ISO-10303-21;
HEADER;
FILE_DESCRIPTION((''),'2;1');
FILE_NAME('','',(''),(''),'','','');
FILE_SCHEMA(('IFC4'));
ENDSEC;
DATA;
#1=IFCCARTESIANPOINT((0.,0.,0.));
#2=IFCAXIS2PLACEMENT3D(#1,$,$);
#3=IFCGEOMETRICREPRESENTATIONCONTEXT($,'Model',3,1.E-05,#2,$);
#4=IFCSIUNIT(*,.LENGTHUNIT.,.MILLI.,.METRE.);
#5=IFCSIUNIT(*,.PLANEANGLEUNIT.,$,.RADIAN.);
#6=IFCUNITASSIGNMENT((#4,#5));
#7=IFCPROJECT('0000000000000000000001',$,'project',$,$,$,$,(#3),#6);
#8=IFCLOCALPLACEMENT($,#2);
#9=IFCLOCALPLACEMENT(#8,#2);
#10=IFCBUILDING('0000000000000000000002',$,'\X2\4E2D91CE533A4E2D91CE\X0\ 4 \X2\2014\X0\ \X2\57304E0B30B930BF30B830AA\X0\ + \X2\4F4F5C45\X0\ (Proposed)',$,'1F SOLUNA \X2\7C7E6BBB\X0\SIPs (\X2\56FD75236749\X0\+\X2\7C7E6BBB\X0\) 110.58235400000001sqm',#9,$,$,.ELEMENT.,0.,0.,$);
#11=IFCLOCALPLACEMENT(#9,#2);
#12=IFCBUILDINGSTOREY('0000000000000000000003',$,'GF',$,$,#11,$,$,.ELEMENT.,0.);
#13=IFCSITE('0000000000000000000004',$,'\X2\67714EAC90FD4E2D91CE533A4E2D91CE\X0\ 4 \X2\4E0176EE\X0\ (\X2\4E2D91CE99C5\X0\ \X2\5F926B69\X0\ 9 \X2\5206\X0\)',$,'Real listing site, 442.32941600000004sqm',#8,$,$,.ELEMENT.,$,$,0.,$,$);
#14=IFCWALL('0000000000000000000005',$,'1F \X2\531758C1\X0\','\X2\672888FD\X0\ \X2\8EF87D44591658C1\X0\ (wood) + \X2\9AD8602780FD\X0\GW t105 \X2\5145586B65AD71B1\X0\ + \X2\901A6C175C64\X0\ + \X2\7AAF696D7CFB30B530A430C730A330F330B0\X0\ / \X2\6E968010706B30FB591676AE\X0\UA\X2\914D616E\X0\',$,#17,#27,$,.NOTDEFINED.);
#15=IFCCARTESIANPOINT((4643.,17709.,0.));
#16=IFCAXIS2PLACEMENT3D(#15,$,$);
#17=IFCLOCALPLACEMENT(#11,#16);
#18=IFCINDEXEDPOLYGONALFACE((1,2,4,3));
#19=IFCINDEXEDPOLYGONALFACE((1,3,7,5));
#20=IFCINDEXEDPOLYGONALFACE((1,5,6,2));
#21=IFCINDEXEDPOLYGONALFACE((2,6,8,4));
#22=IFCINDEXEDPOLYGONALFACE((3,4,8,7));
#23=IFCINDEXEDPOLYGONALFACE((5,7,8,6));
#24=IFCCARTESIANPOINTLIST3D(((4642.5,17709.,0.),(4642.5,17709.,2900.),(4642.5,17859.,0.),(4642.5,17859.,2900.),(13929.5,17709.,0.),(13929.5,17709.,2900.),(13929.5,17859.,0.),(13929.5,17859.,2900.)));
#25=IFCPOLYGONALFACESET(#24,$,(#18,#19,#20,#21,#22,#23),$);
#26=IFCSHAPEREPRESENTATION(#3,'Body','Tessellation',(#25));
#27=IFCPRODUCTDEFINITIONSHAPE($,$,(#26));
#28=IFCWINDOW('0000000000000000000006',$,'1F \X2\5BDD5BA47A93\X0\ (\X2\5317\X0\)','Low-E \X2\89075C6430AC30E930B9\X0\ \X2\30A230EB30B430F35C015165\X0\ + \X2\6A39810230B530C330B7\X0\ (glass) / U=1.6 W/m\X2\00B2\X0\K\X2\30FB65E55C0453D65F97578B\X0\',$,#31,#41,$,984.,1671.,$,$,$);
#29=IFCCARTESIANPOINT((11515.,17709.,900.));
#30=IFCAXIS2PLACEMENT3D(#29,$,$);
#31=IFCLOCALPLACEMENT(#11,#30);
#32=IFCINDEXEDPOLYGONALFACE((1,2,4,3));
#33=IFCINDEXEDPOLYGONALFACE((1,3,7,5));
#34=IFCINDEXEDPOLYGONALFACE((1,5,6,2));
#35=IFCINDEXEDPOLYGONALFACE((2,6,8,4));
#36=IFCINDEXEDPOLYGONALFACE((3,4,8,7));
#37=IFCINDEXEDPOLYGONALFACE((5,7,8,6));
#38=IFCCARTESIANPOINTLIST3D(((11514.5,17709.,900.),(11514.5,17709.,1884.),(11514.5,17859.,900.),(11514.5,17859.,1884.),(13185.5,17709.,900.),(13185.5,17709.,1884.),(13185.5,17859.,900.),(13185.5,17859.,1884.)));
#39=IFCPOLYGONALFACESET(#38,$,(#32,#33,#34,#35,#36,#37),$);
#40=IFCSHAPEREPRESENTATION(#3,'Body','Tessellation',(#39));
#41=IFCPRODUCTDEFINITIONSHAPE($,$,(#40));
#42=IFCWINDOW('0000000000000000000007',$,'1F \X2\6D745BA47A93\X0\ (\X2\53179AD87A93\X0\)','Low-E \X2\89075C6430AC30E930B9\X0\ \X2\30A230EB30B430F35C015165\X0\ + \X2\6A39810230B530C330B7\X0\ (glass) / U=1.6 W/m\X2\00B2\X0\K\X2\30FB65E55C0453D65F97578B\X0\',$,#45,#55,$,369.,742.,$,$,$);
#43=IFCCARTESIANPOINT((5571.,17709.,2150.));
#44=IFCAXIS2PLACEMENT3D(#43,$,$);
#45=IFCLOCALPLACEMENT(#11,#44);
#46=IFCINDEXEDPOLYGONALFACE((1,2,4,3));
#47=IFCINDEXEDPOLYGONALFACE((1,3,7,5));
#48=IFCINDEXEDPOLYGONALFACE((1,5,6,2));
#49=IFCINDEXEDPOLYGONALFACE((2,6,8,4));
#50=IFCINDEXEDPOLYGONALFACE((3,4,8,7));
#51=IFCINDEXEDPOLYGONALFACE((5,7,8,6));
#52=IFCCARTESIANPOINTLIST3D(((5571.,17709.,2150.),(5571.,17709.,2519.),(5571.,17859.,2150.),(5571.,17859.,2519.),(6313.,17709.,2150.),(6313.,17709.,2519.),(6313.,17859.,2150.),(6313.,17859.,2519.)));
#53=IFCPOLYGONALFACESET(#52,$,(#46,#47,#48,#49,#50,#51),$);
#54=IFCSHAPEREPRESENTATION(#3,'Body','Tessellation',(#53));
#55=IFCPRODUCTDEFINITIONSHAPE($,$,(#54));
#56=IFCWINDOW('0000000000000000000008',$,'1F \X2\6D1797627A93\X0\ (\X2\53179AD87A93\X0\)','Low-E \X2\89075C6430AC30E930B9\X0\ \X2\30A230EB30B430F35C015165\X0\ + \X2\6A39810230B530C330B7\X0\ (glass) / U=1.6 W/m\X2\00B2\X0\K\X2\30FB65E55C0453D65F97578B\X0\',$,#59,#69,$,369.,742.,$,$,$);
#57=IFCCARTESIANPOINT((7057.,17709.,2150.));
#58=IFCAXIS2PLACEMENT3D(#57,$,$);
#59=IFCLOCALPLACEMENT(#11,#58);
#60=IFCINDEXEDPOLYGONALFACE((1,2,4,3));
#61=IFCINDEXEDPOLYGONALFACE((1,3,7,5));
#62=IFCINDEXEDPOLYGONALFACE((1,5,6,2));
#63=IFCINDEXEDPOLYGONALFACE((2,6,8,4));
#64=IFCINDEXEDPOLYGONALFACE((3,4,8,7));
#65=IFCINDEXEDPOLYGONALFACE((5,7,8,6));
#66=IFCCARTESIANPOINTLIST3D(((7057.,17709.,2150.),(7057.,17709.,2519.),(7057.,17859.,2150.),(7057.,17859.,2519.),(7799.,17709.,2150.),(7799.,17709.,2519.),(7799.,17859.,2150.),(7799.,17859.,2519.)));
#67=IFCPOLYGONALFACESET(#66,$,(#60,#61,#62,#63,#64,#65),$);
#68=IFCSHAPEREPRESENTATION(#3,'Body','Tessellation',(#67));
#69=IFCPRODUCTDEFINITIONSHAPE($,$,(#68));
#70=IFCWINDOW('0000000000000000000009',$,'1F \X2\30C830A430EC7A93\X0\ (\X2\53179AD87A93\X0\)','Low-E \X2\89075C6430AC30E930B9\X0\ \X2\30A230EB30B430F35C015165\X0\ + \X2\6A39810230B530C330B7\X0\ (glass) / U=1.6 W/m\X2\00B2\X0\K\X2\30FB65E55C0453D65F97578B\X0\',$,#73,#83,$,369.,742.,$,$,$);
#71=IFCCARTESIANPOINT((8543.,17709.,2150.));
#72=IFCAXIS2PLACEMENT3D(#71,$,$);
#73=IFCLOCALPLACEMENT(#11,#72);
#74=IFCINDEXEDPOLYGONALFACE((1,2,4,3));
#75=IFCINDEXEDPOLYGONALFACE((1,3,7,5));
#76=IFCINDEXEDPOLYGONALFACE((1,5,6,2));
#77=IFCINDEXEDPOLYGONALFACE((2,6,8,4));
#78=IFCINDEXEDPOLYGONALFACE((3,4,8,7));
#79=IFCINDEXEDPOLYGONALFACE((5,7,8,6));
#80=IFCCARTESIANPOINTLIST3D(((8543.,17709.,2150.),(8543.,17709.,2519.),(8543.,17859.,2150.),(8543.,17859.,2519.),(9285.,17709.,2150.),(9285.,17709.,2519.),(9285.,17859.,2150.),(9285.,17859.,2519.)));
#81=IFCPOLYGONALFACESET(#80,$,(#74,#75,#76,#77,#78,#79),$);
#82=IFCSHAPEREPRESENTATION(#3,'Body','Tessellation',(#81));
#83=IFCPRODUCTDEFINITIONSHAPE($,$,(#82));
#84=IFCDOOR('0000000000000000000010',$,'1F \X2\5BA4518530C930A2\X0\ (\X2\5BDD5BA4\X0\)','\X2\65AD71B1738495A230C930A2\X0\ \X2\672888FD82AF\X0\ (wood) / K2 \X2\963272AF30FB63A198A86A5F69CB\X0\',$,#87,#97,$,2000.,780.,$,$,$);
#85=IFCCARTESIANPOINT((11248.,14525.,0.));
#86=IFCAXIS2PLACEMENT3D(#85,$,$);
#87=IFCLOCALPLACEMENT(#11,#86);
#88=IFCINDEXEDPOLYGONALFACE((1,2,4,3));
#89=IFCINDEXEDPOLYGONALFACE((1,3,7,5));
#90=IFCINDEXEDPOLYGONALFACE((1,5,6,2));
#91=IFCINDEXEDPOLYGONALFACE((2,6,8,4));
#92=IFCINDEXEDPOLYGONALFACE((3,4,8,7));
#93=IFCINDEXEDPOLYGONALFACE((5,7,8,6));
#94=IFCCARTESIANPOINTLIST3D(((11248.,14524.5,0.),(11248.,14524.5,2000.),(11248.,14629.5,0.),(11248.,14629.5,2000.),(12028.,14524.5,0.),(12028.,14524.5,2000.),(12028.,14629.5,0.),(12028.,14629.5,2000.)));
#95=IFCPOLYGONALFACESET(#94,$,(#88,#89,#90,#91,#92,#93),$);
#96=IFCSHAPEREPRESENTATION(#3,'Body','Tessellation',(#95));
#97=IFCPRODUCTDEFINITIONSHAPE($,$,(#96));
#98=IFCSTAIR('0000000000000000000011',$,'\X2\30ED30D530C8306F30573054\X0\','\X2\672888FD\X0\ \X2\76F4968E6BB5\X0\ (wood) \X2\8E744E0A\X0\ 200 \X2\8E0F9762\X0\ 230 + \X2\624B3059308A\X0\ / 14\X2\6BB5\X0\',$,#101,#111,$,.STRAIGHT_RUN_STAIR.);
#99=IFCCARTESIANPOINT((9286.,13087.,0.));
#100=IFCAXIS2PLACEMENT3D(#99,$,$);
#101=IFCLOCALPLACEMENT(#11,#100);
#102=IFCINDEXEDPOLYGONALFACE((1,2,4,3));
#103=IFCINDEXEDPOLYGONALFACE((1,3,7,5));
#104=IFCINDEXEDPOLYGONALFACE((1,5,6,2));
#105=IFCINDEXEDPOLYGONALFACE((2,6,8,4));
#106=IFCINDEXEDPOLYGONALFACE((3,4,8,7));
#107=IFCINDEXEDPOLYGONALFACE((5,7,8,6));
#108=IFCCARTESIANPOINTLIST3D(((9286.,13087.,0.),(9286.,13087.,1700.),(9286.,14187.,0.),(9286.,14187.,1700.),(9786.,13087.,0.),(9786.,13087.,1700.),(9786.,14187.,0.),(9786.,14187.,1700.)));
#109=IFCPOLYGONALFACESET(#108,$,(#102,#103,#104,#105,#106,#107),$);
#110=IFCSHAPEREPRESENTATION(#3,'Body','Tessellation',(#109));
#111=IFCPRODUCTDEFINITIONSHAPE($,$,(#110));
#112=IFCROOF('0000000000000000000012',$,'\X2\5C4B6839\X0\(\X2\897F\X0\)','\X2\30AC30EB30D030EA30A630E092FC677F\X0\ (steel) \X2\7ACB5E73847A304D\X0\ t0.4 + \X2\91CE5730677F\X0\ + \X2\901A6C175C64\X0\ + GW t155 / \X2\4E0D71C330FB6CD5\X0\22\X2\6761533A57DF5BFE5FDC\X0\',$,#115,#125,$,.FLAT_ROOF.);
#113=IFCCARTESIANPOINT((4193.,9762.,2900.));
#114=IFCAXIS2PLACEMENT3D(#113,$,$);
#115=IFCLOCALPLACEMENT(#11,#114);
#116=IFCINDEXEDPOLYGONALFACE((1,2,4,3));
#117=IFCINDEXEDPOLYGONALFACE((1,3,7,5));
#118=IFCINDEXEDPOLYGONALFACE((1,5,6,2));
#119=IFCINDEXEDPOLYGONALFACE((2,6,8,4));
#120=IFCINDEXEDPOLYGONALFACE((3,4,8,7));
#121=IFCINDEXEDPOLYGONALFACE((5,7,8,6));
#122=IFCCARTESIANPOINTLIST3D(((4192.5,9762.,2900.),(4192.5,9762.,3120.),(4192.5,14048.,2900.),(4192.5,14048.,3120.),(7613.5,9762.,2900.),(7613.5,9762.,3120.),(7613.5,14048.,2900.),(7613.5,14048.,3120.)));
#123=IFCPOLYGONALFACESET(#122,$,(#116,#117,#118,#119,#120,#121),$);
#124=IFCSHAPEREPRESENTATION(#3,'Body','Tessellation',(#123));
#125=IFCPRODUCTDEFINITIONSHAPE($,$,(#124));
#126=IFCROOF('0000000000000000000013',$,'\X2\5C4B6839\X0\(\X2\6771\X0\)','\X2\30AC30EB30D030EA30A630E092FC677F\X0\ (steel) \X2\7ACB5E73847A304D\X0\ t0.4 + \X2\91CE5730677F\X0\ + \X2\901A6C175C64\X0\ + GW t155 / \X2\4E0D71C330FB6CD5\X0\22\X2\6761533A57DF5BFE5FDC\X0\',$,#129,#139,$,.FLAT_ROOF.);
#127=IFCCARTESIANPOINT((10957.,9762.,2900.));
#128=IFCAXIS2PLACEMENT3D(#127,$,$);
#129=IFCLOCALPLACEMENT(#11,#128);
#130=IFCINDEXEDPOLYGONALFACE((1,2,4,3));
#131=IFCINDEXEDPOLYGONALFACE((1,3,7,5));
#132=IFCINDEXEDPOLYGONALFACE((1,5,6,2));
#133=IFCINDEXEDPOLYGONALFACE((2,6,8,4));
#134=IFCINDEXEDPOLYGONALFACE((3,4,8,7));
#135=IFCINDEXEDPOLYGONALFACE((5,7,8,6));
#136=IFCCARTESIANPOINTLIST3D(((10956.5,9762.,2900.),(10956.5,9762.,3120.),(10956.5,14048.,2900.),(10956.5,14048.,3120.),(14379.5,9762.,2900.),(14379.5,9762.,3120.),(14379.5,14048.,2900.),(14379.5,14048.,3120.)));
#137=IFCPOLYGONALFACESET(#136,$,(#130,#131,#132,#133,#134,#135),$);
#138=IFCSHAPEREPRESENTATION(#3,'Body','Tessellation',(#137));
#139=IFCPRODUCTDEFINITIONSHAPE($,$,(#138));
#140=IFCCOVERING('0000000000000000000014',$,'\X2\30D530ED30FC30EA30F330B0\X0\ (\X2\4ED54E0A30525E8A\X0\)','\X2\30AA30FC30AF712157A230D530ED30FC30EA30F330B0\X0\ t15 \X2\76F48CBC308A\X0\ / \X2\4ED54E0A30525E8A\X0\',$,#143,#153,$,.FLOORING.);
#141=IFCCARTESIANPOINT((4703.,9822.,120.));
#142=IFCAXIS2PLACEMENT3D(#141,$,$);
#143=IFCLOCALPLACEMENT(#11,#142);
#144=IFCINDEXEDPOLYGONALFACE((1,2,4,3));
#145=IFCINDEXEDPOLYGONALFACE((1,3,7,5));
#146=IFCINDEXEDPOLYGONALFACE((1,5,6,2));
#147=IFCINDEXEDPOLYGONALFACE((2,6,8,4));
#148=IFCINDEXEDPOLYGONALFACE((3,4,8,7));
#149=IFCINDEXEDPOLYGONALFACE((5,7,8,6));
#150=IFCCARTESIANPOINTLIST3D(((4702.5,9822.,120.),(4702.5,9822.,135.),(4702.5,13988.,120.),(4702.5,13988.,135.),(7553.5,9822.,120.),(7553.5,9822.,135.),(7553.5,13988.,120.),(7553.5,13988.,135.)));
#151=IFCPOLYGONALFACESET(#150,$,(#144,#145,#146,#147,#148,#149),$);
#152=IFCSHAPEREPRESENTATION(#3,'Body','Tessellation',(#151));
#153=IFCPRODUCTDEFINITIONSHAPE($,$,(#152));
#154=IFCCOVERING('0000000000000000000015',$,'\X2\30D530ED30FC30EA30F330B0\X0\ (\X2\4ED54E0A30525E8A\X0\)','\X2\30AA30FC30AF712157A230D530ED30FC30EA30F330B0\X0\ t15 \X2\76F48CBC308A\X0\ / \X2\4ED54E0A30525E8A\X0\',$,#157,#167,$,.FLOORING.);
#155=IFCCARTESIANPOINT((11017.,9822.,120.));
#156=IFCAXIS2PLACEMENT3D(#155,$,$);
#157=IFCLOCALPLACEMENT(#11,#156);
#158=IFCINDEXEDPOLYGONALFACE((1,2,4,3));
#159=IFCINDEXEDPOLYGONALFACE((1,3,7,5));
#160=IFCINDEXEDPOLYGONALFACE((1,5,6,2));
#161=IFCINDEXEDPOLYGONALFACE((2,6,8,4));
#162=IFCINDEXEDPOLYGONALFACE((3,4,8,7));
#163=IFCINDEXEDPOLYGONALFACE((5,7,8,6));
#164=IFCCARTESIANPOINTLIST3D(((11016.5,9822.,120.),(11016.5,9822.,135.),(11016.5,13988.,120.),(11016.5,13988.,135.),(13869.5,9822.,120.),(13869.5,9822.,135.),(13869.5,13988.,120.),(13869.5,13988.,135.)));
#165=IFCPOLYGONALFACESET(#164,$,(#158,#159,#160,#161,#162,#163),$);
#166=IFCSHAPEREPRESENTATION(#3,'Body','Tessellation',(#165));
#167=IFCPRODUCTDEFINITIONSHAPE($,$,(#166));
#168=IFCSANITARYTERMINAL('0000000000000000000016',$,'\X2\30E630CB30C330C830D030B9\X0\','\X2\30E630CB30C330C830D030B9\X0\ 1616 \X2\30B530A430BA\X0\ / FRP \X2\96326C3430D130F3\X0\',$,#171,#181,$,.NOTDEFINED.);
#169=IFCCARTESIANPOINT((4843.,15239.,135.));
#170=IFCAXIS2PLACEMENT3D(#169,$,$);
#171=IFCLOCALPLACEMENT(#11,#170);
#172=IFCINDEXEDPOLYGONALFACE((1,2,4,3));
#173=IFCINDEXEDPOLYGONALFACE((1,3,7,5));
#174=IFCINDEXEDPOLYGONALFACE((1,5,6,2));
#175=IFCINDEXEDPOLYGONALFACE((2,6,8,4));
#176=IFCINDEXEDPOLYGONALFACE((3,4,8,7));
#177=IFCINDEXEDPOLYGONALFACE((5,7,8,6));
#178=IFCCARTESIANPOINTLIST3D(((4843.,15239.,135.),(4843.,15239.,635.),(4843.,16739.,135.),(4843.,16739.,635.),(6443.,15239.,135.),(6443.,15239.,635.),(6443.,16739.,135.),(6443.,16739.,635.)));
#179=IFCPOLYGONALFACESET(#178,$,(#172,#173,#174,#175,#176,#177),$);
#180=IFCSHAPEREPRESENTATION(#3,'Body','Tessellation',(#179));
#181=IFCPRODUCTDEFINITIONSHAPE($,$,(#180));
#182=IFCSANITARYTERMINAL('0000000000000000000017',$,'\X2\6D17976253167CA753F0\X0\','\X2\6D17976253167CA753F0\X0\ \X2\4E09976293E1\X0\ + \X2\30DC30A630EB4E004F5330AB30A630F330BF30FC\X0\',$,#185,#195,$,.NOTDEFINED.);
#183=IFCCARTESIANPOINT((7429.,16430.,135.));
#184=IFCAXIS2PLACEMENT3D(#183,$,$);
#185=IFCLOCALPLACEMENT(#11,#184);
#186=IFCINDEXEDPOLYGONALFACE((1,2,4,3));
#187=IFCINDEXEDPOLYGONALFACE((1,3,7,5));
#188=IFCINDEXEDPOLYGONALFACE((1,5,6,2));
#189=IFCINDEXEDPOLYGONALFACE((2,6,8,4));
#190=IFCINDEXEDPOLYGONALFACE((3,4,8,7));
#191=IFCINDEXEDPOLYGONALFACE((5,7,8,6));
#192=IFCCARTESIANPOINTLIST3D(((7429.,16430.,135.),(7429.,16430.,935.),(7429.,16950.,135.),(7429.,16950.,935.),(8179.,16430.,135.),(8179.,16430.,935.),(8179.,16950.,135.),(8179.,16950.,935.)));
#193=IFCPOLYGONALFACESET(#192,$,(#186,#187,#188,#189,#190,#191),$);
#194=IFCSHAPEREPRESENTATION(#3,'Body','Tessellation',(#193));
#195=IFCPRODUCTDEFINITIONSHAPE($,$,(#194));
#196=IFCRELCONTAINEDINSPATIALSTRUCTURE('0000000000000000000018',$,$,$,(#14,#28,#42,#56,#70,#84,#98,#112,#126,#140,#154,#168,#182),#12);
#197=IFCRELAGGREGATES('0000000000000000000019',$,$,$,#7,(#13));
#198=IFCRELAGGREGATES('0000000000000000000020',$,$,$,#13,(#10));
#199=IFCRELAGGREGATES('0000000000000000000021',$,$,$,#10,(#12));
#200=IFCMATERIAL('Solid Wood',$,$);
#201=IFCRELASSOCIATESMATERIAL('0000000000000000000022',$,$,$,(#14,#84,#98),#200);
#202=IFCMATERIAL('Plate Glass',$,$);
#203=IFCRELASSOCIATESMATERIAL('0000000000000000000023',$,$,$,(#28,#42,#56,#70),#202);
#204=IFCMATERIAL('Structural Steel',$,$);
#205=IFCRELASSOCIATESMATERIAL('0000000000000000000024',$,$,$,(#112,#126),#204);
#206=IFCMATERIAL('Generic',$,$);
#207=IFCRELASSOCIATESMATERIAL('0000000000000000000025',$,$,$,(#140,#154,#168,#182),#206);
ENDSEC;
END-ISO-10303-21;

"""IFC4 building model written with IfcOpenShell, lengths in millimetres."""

from ifc_helpers import new_model, si_unit, frame, frame_2d, origin, place, context, project, spatial, rectangle, extrude, material, element, fill, save


model = new_model("IFC4")

# Units and contexts
model_context = context("Model", 3, precision=1e-05, world=origin())
ifc_project = project(units=[si_unit("LENGTHUNIT", "METRE", prefix="MILLI"), si_unit("PLANEANGLEUNIT", "RADIAN")], contexts=[model_context])

# Site, building, storey
site_placement = place(None, origin())
site = spatial("IfcSite", under=ifc_project, at=site_placement, Name="東京都中野区中野 4 丁目 (中野駅 徒歩 9 分)", ObjectType="Real listing site, 442.32941600000004sqm", CompositionType="ELEMENT", RefElevation=0.0)
building_placement = place(site_placement, origin())
building = spatial("IfcBuilding", under=site, at=building_placement, Name="中野区中野 4 — 地下スタジオ + 住居 (Proposed)", ObjectType="1F SOLUNA 籾殻SIPs (国産杉+籾殻) 110.58235400000001sqm", CompositionType="ELEMENT", ElevationOfRefHeight=0.0, ElevationOfTerrain=0.0)
storey_placement = place(building_placement, origin())
storey = spatial("IfcBuildingStorey", under=building, at=storey_placement, Name="GF", CompositionType="ELEMENT", Elevation=0.0)

# Shared definitions
ifc_material_1 = material(Name="Solid Wood")

# Wall, openings, windows
wall_1_placement = place(storey_placement, frame((4643.0, 17709.0, 0.0)))
wall_1 = element("IfcWall", 1, at=wall_1_placement, inside=storey, material=ifc_material_1, Name="1F 北壁", Description="木製 軸組外壁 (wood) + 高性能GW t105 充填断熱 + 通気層 + 窯業系サイディング / 準耐火・外皮UA配慮", PredefinedType="NOTDEFINED", context=model_context, shape_type="SweptSolid", body=[
    extrude(rectangle(XDim=9287.0, YDim=150.0, at=frame_2d((4643.0, 75.0))), frame((4643.0, 17709.0, 0.0)), (0.0, 0.0, 1.0), 2900.0),
])
opening_1_placement = place(storey_placement, frame((11515.0, 17709.0, 900.0)))
opening_1 = element("IfcOpeningElement", 2, at=opening_1_placement, cuts=wall_1, PredefinedType="NOTDEFINED", context=model_context, shape_type="SweptSolid", body=[
    extrude(rectangle(XDim=1671.0, YDim=150.0, at=frame_2d((835.0, 75.0))), frame((11515.0, 17709.0, 900.0)), (0.0, 0.0, 1.0), 984.0),
])
opening_2_placement = place(storey_placement, frame((5571.0, 17709.0, 2150.0)))
opening_2 = element("IfcOpeningElement", 3, at=opening_2_placement, cuts=wall_1, PredefinedType="NOTDEFINED", context=model_context, shape_type="SweptSolid", body=[
    extrude(rectangle(XDim=742.0, YDim=150.0, at=frame_2d((371.0, 75.0))), frame((5571.0, 17709.0, 2150.0)), (0.0, 0.0, 1.0), 369.0),
])
opening_3_placement = place(storey_placement, frame((7057.0, 17709.0, 2150.0)))
opening_3 = element("IfcOpeningElement", 4, at=opening_3_placement, cuts=wall_1, PredefinedType="NOTDEFINED", context=model_context, shape_type="SweptSolid", body=[
    extrude(rectangle(XDim=742.0, YDim=150.0, at=frame_2d((371.0, 75.0))), frame((7057.0, 17709.0, 2150.0)), (0.0, 0.0, 1.0), 369.0),
])
opening_4_placement = place(storey_placement, frame((8543.0, 17709.0, 2150.0)))
opening_4 = element("IfcOpeningElement", 5, at=opening_4_placement, cuts=wall_1, PredefinedType="NOTDEFINED", context=model_context, shape_type="SweptSolid", body=[
    extrude(rectangle(XDim=742.0, YDim=150.0, at=frame_2d((371.0, 75.0))), frame((8543.0, 17709.0, 2150.0)), (0.0, 0.0, 1.0), 369.0),
])
ifc_material_2 = material(Name="Plate Glass")
window_1_placement = place(storey_placement, frame((11515.0, 17709.0, 900.0)))
window_1 = element("IfcWindow", 6, at=window_1_placement, inside=storey, material=ifc_material_2, Name="1F 寝室窓 (北)", Description="Low-E 複層ガラス アルゴン封入 + 樹脂サッシ (glass) / U=1.6 W/m²K・日射取得型", OverallHeight=984.0, OverallWidth=1671.0, context=model_context, shape_type="SweptSolid", body=[
    extrude(rectangle(XDim=1671.0, YDim=150.0, at=frame_2d((835.0, 75.0))), frame((11515.0, 17709.0, 900.0)), (0.0, 0.0, 1.0), 984.0),
])
fill(opening_1, window_1)
window_2_placement = place(storey_placement, frame((5571.0, 17709.0, 2150.0)))
window_2 = element("IfcWindow", 7, at=window_2_placement, inside=storey, material=ifc_material_2, Name="1F 浴室窓 (北高窓)", Description="Low-E 複層ガラス アルゴン封入 + 樹脂サッシ (glass) / U=1.6 W/m²K・日射取得型", OverallHeight=369.0, OverallWidth=742.0, context=model_context, shape_type="SweptSolid", body=[
    extrude(rectangle(XDim=742.0, YDim=150.0, at=frame_2d((371.0, 75.0))), frame((5571.0, 17709.0, 2150.0)), (0.0, 0.0, 1.0), 369.0),
])
fill(opening_2, window_2)
window_3_placement = place(storey_placement, frame((7057.0, 17709.0, 2150.0)))
window_3 = element("IfcWindow", 8, at=window_3_placement, inside=storey, material=ifc_material_2, Name="1F 洗面窓 (北高窓)", Description="Low-E 複層ガラス アルゴン封入 + 樹脂サッシ (glass) / U=1.6 W/m²K・日射取得型", OverallHeight=369.0, OverallWidth=742.0, context=model_context, shape_type="SweptSolid", body=[
    extrude(rectangle(XDim=742.0, YDim=150.0, at=frame_2d((371.0, 75.0))), frame((7057.0, 17709.0, 2150.0)), (0.0, 0.0, 1.0), 369.0),
])
fill(opening_3, window_3)
window_4_placement = place(storey_placement, frame((8543.0, 17709.0, 2150.0)))
window_4 = element("IfcWindow", 9, at=window_4_placement, inside=storey, material=ifc_material_2, Name="1F トイレ窓 (北高窓)", Description="Low-E 複層ガラス アルゴン封入 + 樹脂サッシ (glass) / U=1.6 W/m²K・日射取得型", OverallHeight=369.0, OverallWidth=742.0, context=model_context, shape_type="SweptSolid", body=[
    extrude(rectangle(XDim=742.0, YDim=150.0, at=frame_2d((371.0, 75.0))), frame((8543.0, 17709.0, 2150.0)), (0.0, 0.0, 1.0), 369.0),
])
fill(opening_4, window_4)

# Door
door_1_placement = place(storey_placement, frame((11248.0, 14525.0, 0.0)))
element("IfcDoor", 10, at=door_1_placement, inside=storey, material=ifc_material_1, Name="1F 室内ドア (寝室)", Description="断熱玄関ドア 木製芯 (wood) / K2 防犯・採風機構", OverallHeight=2000.0, OverallWidth=780.0, context=model_context, shape_type="SweptSolid", body=[
    extrude(rectangle(XDim=780.0, YDim=105.0, at=frame_2d((390.0, 52.0))), frame((11248.0, 14525.0, 0.0)), (0.0, 0.0, 1.0), 2000.0),
])

# Stair
stair_placement = place(storey_placement, frame((9286.0, 13087.0, 0.0)))
element("IfcStair", 11, at=stair_placement, inside=storey, material=ifc_material_1, Name="ロフトはしご", Description="木製 直階段 (wood) 蹴上 200 踏面 230 + 手すり / 14段", PredefinedType="STRAIGHT_RUN_STAIR", context=model_context, shape_type="SweptSolid", body=[
    extrude(rectangle(XDim=500.0, YDim=1100.0, at=frame_2d((250.0, 550.0))), frame((9286.0, 13087.0, 0.0)), (0.0, 0.0, 1.0), 1700.0),
])

# Roofs
ifc_material_3 = material(Name="Structural Steel")
roof_1_placement = place(storey_placement, frame((4193.0, 9762.0, 2900.0)))
element("IfcRoof", 12, at=roof_1_placement, inside=storey, material=ifc_material_3, Name="屋根(西)", Description="ガルバリウム鋼板 (steel) 立平葺き t0.4 + 野地板 + 通気層 + GW t155 / 不燃・法22条区域対応", PredefinedType="FLAT_ROOF", context=model_context, shape_type="SweptSolid", body=[
    extrude(rectangle(XDim=3421.0, YDim=4286.0, at=frame_2d((1710.0, 2143.0))), frame((4193.0, 9762.0, 2900.0)), (0.0, 0.0, 1.0), 220.0),
])
roof_2_placement = place(storey_placement, frame((10957.0, 9762.0, 2900.0)))
element("IfcRoof", 13, at=roof_2_placement, inside=storey, material=ifc_material_3, Name="屋根(東)", Description="ガルバリウム鋼板 (steel) 立平葺き t0.4 + 野地板 + 通気層 + GW t155 / 不燃・法22条区域対応", PredefinedType="FLAT_ROOF", context=model_context, shape_type="SweptSolid", body=[
    extrude(rectangle(XDim=3423.0, YDim=4286.0, at=frame_2d((1711.0, 2143.0))), frame((10957.0, 9762.0, 2900.0)), (0.0, 0.0, 1.0), 220.0),
])

# Coverings
ifc_material_4 = material(Name="Generic")
covering_1_placement = place(storey_placement, frame((4703.0, 9822.0, 120.0)))
element("IfcCovering", 14, at=covering_1_placement, inside=storey, material=ifc_material_4, Name="フローリング (仕上げ床)", Description="オーク無垢フローリング t15 直貼り / 仕上げ床", PredefinedType="FLOORING", context=model_context, shape_type="SweptSolid", body=[
    extrude(rectangle(XDim=2851.0, YDim=4166.0, at=frame_2d((1425.0, 2083.0))), frame((4703.0, 9822.0, 120.0)), (0.0, 0.0, 1.0), 15.0),
])
covering_2_placement = place(storey_placement, frame((11017.0, 9822.0, 120.0)))
element("IfcCovering", 15, at=covering_2_placement, inside=storey, material=ifc_material_4, Name="フローリング (仕上げ床)", Description="オーク無垢フローリング t15 直貼り / 仕上げ床", PredefinedType="FLOORING", context=model_context, shape_type="SweptSolid", body=[
    extrude(rectangle(XDim=2853.0, YDim=4166.0, at=frame_2d((1426.0, 2083.0))), frame((11017.0, 9822.0, 120.0)), (0.0, 0.0, 1.0), 15.0),
])

# Sanitary terminals
sanitary_terminal_1_placement = place(storey_placement, frame((4843.0, 15239.0, 135.0)))
element("IfcSanitaryTerminal", 16, at=sanitary_terminal_1_placement, inside=storey, material=ifc_material_4, Name="ユニットバス", Description="ユニットバス 1616 サイズ / FRP 防水パン", PredefinedType="NOTDEFINED", context=model_context, shape_type="SweptSolid", body=[
    extrude(rectangle(XDim=1600.0, YDim=1500.0, at=frame_2d((800.0, 750.0))), frame((4843.0, 15239.0, 135.0)), (0.0, 0.0, 1.0), 500.0),
])
sanitary_terminal_2_placement = place(storey_placement, frame((7429.0, 16430.0, 135.0)))
element("IfcSanitaryTerminal", 17, at=sanitary_terminal_2_placement, inside=storey, material=ifc_material_4, Name="洗面化粧台", Description="洗面化粧台 三面鏡 + ボウル一体カウンター", PredefinedType="NOTDEFINED", context=model_context, shape_type="SweptSolid", body=[
    extrude(rectangle(XDim=750.0, YDim=520.0, at=frame_2d((375.0, 260.0))), frame((7429.0, 16430.0, 135.0)), (0.0, 0.0, 1.0), 800.0),
])

save(model, "model.ifc")
